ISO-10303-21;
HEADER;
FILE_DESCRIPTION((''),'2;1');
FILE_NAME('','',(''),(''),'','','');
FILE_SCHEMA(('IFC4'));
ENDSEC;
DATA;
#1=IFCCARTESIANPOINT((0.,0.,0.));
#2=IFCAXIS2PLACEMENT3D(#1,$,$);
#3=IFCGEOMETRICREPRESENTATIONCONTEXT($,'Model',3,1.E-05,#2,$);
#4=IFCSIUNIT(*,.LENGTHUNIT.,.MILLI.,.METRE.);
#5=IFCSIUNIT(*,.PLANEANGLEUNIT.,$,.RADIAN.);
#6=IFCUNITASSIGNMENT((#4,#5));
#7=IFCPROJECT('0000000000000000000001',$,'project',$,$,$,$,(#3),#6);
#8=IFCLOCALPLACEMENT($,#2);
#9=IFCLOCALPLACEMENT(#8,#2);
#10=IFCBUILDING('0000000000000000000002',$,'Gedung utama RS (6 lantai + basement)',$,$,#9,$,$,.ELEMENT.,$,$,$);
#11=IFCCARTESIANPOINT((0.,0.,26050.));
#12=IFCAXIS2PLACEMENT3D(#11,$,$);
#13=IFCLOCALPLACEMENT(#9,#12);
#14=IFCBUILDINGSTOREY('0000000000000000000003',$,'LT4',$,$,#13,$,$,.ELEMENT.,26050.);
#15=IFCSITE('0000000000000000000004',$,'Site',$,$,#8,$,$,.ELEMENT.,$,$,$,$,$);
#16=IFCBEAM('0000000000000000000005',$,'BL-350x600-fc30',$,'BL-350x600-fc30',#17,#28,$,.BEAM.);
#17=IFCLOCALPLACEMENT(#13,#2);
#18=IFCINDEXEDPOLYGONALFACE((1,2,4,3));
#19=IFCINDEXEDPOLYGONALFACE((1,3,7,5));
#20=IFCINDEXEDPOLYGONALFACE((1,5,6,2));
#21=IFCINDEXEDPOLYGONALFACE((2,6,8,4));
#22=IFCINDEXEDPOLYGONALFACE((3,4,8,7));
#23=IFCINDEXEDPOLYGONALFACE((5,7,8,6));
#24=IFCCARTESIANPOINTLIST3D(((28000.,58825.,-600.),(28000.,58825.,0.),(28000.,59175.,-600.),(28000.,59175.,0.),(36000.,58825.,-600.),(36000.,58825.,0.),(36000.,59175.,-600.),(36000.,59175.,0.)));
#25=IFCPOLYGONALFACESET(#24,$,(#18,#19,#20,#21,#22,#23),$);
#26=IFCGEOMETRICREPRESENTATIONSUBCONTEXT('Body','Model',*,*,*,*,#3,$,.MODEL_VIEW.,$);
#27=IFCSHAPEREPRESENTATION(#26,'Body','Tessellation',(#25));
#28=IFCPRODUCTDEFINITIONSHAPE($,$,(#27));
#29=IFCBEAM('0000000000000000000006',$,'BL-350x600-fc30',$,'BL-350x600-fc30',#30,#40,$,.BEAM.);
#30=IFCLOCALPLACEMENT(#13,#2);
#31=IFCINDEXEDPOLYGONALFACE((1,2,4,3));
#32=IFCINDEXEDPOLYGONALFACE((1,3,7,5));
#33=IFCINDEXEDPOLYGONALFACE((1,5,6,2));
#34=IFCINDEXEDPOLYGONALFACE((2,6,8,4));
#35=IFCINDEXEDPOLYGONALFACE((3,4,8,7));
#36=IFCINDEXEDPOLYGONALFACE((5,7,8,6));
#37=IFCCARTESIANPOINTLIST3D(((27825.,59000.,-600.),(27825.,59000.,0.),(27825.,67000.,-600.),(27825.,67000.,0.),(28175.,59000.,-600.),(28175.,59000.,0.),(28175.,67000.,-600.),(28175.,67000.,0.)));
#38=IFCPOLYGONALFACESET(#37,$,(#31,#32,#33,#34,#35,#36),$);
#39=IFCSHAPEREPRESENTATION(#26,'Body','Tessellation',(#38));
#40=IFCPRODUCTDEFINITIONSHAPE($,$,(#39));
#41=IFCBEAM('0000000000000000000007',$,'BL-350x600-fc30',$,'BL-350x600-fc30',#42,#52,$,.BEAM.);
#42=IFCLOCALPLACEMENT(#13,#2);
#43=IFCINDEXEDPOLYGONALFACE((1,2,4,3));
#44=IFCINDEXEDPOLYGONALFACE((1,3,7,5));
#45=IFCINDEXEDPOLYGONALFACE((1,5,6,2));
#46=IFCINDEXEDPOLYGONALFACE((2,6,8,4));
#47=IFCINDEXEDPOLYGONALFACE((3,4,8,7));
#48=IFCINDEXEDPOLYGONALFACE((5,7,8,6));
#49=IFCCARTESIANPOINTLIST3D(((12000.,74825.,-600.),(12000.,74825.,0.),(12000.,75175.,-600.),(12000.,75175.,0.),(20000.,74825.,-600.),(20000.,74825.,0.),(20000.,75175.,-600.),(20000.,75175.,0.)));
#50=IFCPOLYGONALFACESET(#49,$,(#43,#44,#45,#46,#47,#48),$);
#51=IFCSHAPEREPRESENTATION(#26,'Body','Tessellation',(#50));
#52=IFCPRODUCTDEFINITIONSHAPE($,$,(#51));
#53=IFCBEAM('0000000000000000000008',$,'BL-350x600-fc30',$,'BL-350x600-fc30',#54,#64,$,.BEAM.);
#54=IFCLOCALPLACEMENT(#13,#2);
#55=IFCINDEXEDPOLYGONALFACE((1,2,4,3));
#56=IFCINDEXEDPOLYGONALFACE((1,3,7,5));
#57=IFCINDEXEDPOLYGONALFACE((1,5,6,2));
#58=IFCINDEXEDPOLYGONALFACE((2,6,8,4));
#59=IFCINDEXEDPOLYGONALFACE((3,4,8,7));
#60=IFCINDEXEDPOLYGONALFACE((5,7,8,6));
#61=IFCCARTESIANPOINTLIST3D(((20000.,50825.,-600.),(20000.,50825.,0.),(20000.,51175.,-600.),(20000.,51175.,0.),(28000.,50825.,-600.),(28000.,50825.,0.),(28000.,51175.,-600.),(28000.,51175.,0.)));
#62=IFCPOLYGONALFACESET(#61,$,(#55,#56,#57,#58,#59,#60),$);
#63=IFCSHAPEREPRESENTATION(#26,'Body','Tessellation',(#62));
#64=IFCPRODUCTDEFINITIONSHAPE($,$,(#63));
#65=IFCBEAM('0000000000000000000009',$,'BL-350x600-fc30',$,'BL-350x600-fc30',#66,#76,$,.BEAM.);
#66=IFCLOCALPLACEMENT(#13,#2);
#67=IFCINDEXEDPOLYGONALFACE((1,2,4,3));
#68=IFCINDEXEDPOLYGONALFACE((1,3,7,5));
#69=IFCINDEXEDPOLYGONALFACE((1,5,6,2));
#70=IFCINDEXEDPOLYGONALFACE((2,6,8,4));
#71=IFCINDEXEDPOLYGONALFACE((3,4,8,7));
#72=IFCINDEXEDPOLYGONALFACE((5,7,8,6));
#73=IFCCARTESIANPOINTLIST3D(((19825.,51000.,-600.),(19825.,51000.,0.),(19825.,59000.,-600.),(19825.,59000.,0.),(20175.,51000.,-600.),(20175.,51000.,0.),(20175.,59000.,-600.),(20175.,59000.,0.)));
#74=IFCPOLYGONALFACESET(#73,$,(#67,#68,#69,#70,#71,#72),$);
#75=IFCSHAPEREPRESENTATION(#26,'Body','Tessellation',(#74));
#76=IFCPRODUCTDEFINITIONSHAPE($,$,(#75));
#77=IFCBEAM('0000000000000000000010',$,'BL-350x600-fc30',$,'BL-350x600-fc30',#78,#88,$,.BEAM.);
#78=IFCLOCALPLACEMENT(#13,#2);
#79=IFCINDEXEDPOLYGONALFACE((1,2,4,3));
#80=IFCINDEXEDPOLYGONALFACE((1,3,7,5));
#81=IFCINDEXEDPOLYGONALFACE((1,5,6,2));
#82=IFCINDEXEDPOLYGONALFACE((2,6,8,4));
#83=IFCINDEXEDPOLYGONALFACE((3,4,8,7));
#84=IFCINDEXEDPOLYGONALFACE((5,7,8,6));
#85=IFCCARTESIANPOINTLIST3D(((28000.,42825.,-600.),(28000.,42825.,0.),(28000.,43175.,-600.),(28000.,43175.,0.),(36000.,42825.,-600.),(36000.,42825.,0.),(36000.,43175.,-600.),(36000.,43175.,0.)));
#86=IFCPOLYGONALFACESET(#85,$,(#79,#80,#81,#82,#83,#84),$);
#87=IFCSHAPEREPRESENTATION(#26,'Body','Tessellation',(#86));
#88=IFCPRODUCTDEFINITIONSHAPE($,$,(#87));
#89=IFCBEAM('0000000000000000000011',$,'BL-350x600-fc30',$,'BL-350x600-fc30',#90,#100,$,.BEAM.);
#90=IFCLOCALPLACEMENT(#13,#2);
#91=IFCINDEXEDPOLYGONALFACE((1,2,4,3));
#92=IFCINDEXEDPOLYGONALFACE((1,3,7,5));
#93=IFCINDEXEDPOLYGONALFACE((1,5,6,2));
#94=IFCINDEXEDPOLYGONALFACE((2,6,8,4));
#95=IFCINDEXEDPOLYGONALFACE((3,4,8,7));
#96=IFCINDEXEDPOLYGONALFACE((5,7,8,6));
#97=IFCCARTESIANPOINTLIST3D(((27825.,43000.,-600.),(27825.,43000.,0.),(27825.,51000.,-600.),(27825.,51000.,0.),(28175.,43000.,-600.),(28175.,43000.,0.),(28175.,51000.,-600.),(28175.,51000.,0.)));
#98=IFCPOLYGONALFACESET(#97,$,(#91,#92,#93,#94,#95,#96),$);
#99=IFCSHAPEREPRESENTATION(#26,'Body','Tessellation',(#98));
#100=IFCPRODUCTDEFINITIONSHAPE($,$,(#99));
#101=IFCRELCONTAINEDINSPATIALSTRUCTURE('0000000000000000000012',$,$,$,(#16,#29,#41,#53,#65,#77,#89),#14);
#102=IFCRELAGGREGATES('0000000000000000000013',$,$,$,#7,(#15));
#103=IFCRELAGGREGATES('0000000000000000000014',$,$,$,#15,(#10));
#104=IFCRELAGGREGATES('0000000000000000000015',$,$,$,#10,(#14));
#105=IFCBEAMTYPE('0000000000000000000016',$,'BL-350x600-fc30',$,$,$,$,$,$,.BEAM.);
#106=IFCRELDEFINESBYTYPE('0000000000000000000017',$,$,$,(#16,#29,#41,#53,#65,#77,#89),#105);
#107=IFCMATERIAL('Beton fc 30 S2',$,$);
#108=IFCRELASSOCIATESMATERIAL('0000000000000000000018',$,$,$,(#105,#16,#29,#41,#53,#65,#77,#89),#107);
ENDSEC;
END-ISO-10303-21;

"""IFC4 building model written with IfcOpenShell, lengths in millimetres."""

from ifc_helpers import new_model, si_unit, frame, origin, origin_2d, place, context, subcontext, project, spatial, rectangle, extrude, material, material_profile, profile_set, profile_usage, type_object, element, save


model = new_model("IFC4")

# Units and contexts
model_context = context("Model", 3, precision=1e-05, world=origin())
body_context = subcontext(model_context, "Body", "Model", "MODEL_VIEW")
ifc_project = project(units=[si_unit("LENGTHUNIT", "METRE", prefix="MILLI"), si_unit("PLANEANGLEUNIT", "RADIAN")], contexts=[model_context])

# Site, building, storey
site_placement = place(None, origin())
site = spatial("IfcSite", under=ifc_project, at=site_placement, Name="Site", CompositionType="ELEMENT")
building_placement = place(site_placement, origin())
building = spatial("IfcBuilding", under=site, at=building_placement, Name="Gedung utama RS (6 lantai + basement)", CompositionType="ELEMENT")
storey_placement = place(building_placement, frame((0.0, 0.0, 26050.0)))
storey = spatial("IfcBuildingStorey", under=building, at=storey_placement, Name="LT4", CompositionType="ELEMENT", Elevation=26050.0)

# Beams
ifc_material = material(Name="Beton fc 30 S2")
ifc_material_profile_1 = material_profile(ifc_material, rectangle(XDim=350.0, YDim=600.0, at=origin_2d()), Name="BL-350x600-fc30")
ifc_profile_set_1 = profile_set([ifc_material_profile_1], Name="BL-350x600-fc30")
ifc_profile_usage_1 = profile_usage(ifc_profile_set_1, cardinal=8)
beam_type = type_object("IfcBeamType", Name="BL-350x600-fc30", PredefinedType="BEAM", material=ifc_profile_set_1)
beam_1_placement = place(storey_placement, frame((28000.0, 59000.0, -300.0)))
element("IfcBeam", 1, at=beam_1_placement, inside=storey, type_object=beam_type, material=ifc_profile_usage_1, Name="BL-350x600-fc30", ObjectType="BL-350x600-fc30", PredefinedType="BEAM", context=body_context, shape_type="SweptSolid", body=[
    extrude(rectangle(XDim=350.0, YDim=600.0, at=origin_2d()), frame((0.0, 0.0, 0.0), z_axis=(1.0, 0.0, 0.0), x_axis=(0.0, 1.0, 0.0)), (0.0, 0.0, 1.0), 8000.0),
])
beam_2_placement = place(storey_placement, frame((28000.0, 59000.0, -300.0)))
element("IfcBeam", 2, at=beam_2_placement, inside=storey, type_object=beam_type, material=ifc_profile_usage_1, Name="BL-350x600-fc30", ObjectType="BL-350x600-fc30", PredefinedType="BEAM", context=body_context, shape_type="SweptSolid", body=[
    extrude(rectangle(XDim=350.0, YDim=600.0, at=origin_2d()), frame((0.0, 0.0, 0.0), z_axis=(0.0, 1.0, 0.0), x_axis=(-1.0, 0.0, 0.0)), (0.0, 0.0, 1.0), 8000.0),
])
for number, where, name in (
    (3, (12000.0, 75000.0, -300.0), "BL-350x600-fc30"),
    (4, (20000.0, 51000.0, -300.0), "BL-350x600-fc30"),
):
    element("IfcBeam", number, at=place(storey_placement, frame(where)), inside=storey, type_object=beam_type, material=ifc_profile_usage_1, Name=name, ObjectType="BL-350x600-fc30", PredefinedType="BEAM", context=body_context, shape_type="SweptSolid", body=[
        extrude(rectangle(XDim=350.0, YDim=600.0, at=origin_2d()), frame((0.0, 0.0, 0.0), z_axis=(1.0, 0.0, 0.0), x_axis=(0.0, 1.0, 0.0)), (0.0, 0.0, 1.0), 8000.0),
    ])
beam_3_placement = place(storey_placement, frame((20000.0, 51000.0, -300.0)))
element("IfcBeam", 5, at=beam_3_placement, inside=storey, type_object=beam_type, material=ifc_profile_usage_1, Name="BL-350x600-fc30", ObjectType="BL-350x600-fc30", PredefinedType="BEAM", context=body_context, shape_type="SweptSolid", body=[
    extrude(rectangle(XDim=350.0, YDim=600.0, at=origin_2d()), frame((0.0, 0.0, 0.0), z_axis=(0.0, 1.0, 0.0), x_axis=(-1.0, 0.0, 0.0)), (0.0, 0.0, 1.0), 8000.0),
])
beam_4_placement = place(storey_placement, frame((28000.0, 43000.0, -300.0)))
element("IfcBeam", 6, at=beam_4_placement, inside=storey, type_object=beam_type, material=ifc_profile_usage_1, Name="BL-350x600-fc30", ObjectType="BL-350x600-fc30", PredefinedType="BEAM", context=body_context, shape_type="SweptSolid", body=[
    extrude(rectangle(XDim=350.0, YDim=600.0, at=origin_2d()), frame((0.0, 0.0, 0.0), z_axis=(1.0, 0.0, 0.0), x_axis=(0.0, 1.0, 0.0)), (0.0, 0.0, 1.0), 8000.0),
])
beam_5_placement = place(storey_placement, frame((28000.0, 43000.0, -300.0)))
element("IfcBeam", 7, at=beam_5_placement, inside=storey, type_object=beam_type, material=ifc_profile_usage_1, Name="BL-350x600-fc30", ObjectType="BL-350x600-fc30", PredefinedType="BEAM", context=body_context, shape_type="SweptSolid", body=[
    extrude(rectangle(XDim=350.0, YDim=600.0, at=origin_2d()), frame((0.0, 0.0, 0.0), z_axis=(0.0, 1.0, 0.0), x_axis=(-1.0, 0.0, 0.0)), (0.0, 0.0, 1.0), 8000.0),
])

save(model, "model.ifc")
